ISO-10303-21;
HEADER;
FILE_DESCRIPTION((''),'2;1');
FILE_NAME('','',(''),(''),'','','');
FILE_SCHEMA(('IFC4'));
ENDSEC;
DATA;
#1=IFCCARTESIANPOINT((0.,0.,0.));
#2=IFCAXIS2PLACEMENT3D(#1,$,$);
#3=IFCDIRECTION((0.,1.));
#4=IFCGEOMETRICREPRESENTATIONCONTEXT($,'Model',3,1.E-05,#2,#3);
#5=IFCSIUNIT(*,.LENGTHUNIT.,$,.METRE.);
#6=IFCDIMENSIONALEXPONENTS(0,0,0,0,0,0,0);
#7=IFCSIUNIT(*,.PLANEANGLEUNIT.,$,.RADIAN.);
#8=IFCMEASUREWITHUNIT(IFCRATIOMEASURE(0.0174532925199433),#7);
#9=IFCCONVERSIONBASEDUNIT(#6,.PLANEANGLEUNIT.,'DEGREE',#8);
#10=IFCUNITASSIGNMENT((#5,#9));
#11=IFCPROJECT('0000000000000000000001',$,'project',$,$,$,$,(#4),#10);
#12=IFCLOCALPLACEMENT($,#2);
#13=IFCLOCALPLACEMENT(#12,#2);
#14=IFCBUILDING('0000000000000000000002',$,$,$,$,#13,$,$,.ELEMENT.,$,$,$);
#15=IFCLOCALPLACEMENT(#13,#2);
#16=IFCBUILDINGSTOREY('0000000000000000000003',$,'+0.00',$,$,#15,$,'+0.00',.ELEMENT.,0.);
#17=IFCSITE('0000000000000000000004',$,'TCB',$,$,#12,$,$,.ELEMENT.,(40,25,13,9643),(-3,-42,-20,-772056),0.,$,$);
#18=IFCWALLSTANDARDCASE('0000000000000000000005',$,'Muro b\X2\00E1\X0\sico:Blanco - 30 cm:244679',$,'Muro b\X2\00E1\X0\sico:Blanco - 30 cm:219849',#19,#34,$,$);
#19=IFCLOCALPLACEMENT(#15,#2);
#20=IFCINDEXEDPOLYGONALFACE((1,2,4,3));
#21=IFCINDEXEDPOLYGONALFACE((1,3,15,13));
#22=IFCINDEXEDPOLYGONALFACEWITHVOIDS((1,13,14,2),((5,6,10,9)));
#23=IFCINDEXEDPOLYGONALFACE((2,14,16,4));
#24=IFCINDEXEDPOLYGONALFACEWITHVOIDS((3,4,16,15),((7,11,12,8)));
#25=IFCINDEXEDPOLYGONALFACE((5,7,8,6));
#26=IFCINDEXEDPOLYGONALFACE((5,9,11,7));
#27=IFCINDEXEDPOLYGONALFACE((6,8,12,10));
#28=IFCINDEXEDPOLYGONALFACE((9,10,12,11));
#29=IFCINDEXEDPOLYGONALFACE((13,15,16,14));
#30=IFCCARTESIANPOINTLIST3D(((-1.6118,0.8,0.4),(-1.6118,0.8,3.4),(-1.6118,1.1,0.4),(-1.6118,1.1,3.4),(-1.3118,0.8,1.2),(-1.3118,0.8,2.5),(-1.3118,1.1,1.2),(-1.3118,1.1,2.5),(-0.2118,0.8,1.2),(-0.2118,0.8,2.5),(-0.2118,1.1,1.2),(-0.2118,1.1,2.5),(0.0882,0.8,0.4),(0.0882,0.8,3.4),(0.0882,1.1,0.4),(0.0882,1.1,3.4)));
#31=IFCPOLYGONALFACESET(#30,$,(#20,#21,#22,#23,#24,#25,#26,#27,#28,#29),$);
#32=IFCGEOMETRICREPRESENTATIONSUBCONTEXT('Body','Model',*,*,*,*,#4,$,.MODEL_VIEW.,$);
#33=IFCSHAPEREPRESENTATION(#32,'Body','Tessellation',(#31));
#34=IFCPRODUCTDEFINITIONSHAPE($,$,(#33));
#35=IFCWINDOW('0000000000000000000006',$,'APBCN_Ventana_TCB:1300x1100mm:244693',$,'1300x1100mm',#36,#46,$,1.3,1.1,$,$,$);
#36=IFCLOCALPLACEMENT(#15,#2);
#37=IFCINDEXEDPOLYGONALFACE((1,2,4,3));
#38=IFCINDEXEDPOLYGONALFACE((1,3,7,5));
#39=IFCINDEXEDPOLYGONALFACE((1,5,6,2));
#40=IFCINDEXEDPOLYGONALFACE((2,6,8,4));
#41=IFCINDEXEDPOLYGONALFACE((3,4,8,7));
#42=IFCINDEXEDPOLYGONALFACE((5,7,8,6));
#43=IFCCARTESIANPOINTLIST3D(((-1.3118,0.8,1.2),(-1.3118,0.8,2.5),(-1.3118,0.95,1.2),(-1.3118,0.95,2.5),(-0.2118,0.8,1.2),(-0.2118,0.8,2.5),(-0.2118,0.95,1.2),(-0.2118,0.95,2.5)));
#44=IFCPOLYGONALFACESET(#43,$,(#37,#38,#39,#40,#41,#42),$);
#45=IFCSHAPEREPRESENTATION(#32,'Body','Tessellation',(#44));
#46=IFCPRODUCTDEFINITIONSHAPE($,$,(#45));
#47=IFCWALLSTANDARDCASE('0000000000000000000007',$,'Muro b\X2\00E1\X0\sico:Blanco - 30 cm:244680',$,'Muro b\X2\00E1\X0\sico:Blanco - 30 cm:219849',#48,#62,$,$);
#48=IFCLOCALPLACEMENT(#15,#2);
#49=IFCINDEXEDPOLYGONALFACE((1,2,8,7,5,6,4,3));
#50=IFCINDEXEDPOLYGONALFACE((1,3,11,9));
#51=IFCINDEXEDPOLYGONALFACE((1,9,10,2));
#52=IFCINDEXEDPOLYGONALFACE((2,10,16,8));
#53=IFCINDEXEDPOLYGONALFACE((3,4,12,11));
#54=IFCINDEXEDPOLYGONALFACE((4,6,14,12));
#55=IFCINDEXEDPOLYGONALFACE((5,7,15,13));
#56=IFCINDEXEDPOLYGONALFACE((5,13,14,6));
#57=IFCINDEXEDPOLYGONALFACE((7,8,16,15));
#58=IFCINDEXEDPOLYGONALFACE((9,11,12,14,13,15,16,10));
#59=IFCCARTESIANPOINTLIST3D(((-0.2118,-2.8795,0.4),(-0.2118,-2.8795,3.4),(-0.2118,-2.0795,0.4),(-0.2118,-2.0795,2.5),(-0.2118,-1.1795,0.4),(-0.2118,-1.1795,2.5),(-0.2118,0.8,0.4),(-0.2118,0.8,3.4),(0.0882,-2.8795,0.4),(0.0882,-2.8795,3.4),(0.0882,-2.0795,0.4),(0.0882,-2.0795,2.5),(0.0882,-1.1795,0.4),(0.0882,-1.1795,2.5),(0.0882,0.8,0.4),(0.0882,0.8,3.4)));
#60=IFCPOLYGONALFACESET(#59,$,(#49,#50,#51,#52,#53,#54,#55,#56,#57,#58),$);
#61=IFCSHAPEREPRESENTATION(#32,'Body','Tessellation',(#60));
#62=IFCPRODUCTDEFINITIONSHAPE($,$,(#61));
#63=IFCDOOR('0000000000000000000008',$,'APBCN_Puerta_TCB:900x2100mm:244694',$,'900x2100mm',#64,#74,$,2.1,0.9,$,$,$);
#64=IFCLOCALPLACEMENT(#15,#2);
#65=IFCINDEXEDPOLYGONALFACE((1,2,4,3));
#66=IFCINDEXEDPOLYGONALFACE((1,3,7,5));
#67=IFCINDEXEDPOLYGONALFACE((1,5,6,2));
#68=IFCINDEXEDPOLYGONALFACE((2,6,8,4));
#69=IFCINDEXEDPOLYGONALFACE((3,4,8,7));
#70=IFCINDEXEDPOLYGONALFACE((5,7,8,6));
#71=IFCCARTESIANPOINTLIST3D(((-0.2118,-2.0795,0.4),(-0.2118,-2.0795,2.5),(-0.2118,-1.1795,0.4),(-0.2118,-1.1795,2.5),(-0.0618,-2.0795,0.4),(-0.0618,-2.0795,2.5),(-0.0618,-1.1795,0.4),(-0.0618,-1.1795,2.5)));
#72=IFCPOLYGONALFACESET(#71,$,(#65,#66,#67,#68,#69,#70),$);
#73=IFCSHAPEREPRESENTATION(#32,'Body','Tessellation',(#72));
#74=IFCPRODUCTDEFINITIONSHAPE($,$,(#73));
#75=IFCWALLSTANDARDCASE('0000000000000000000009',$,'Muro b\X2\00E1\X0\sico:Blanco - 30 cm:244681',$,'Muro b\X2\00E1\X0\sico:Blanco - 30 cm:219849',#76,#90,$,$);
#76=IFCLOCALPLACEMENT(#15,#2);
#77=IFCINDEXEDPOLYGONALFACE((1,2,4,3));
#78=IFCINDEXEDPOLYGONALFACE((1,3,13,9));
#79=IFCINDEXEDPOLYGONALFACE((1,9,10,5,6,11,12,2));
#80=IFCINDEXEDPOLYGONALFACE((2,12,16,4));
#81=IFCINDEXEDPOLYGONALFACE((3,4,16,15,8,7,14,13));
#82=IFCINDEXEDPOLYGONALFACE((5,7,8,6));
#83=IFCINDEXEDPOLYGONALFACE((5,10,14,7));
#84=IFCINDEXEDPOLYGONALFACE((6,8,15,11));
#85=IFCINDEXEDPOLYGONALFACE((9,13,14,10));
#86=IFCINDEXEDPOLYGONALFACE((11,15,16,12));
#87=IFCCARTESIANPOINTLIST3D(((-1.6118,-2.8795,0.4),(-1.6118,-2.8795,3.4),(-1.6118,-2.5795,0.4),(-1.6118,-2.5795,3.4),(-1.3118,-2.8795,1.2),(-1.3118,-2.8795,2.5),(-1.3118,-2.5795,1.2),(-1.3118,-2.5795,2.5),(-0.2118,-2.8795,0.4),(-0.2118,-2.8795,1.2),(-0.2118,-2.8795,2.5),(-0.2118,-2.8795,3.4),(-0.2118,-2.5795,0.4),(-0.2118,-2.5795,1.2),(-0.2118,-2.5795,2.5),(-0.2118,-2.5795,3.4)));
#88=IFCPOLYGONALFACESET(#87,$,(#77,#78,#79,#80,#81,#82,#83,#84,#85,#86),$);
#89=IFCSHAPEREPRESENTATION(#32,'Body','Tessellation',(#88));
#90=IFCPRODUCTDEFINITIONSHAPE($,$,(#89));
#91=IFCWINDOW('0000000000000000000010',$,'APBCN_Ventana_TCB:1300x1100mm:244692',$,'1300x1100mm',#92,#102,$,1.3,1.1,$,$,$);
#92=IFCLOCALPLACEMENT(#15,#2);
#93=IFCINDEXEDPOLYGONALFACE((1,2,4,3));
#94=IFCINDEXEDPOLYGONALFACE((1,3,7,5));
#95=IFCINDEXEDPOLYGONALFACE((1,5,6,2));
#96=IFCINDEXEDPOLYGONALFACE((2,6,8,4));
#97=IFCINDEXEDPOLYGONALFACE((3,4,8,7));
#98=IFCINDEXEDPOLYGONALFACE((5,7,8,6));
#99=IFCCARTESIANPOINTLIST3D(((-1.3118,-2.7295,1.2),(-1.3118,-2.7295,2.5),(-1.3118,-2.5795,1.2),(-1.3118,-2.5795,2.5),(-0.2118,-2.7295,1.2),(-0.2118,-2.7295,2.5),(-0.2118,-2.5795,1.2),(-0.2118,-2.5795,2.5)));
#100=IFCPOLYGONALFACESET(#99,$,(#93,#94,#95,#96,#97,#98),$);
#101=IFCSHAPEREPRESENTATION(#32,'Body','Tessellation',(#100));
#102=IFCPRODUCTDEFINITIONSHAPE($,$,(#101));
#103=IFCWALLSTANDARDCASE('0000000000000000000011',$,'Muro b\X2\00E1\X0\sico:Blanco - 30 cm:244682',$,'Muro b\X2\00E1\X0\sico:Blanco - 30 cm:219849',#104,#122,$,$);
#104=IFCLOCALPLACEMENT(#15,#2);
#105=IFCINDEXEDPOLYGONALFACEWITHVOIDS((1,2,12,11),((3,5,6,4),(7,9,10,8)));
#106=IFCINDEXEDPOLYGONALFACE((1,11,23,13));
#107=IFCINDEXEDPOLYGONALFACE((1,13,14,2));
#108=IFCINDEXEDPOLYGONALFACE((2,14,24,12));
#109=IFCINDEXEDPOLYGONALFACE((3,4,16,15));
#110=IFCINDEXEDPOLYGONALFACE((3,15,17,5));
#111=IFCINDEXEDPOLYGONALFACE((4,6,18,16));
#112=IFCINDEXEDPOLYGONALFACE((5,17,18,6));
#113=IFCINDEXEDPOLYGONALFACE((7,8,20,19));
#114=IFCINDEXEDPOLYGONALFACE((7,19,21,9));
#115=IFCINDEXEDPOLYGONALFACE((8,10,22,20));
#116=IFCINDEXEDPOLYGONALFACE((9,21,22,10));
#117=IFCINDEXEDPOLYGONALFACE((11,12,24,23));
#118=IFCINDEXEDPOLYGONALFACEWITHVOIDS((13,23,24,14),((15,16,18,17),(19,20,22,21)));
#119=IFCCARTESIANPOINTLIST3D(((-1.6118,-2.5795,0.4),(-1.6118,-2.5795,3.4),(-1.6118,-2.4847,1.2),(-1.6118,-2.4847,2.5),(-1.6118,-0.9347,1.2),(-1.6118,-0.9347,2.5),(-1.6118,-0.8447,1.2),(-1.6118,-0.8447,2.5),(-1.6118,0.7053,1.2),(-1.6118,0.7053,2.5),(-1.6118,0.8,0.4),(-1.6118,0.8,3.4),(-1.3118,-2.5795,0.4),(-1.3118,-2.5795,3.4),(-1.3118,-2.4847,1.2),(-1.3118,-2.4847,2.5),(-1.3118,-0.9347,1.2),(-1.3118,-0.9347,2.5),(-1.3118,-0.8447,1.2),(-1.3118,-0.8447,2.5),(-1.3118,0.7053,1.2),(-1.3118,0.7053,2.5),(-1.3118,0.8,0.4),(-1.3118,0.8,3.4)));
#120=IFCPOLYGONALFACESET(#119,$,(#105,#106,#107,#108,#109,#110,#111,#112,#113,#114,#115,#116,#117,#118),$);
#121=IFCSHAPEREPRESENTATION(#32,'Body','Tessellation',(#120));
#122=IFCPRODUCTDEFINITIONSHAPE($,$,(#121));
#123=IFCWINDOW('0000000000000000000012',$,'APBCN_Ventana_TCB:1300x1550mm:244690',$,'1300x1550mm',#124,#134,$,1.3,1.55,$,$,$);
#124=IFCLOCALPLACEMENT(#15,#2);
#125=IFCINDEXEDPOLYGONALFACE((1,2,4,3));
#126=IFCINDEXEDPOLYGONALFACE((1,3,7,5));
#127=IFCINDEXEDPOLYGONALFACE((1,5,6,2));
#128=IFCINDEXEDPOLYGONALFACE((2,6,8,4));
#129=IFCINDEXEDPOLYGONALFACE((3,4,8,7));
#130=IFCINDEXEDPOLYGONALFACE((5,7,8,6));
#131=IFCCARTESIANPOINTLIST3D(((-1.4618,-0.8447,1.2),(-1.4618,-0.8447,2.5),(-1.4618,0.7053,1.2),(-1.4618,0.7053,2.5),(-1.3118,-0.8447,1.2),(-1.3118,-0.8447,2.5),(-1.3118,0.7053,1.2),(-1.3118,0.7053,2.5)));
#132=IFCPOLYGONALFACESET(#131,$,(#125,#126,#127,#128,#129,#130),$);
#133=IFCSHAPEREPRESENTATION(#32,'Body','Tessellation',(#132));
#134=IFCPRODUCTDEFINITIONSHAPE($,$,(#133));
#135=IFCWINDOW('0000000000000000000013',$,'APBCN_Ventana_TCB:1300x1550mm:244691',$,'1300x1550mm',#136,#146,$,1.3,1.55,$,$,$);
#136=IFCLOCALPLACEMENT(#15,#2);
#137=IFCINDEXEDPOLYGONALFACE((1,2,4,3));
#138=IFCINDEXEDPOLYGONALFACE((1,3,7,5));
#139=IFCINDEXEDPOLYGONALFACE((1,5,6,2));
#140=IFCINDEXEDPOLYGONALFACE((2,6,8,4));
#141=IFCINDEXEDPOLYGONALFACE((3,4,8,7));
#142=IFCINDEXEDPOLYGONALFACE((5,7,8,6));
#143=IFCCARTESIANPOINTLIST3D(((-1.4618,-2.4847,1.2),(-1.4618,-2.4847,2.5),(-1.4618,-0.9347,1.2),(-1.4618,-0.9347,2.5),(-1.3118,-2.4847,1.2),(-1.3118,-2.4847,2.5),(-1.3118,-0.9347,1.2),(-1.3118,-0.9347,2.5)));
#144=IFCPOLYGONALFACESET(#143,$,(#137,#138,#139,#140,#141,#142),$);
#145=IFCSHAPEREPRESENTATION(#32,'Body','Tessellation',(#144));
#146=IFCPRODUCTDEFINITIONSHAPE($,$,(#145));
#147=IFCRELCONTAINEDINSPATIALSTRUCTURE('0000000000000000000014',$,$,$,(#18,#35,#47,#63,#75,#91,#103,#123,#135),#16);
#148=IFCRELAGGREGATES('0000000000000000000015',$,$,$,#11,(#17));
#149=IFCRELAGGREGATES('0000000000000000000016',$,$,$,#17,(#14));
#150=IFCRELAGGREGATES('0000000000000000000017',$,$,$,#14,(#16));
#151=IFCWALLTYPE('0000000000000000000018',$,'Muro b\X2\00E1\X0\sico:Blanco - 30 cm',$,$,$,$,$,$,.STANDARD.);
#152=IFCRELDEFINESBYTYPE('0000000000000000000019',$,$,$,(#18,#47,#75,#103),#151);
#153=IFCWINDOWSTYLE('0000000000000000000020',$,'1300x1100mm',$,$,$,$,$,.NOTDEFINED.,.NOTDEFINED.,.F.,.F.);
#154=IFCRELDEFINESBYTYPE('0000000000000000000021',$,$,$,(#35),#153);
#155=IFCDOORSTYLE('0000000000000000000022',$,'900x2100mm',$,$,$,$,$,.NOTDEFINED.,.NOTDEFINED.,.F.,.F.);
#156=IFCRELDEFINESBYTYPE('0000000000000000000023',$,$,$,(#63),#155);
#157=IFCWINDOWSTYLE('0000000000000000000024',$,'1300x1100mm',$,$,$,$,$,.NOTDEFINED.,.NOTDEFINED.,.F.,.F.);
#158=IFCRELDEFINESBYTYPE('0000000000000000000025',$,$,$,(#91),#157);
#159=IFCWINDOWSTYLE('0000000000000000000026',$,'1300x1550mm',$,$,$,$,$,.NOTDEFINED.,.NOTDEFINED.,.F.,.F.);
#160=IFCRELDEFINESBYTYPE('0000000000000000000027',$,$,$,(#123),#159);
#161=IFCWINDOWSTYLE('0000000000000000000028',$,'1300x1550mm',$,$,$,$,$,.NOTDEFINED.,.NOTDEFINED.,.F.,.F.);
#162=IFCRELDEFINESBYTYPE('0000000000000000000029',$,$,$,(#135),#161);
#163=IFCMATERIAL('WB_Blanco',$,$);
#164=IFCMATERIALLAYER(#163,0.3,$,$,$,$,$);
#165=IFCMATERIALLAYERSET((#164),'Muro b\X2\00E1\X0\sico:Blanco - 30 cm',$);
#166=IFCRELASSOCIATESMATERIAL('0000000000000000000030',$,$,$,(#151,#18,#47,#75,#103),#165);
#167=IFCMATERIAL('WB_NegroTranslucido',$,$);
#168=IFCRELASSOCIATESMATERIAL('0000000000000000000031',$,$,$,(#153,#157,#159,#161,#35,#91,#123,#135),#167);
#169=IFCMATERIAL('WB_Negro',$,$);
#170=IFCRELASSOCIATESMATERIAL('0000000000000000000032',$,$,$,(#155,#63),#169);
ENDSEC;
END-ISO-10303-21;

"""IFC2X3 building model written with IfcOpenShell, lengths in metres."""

from ifc_helpers import new_model, entity, si_unit, converted_unit, direction, frame, frame_2d, origin, origin_2d_with_axis, place, context, subcontext, project, spatial, rectangle, extrude, source, transform, mapped, material, layer, layer_set, layer_usage, type_object, type_shapes, element, fill, save


model = new_model("IFC2X3")

# Units and contexts
model_context = context("Model", 3, precision=1e-05, world=origin(), true_north=direction((0.0, 1.0)))
body_context = subcontext(model_context, "Body", "Model", "MODEL_VIEW")
ifc_project = project(units=[si_unit("LENGTHUNIT", "METRE"), converted_unit("PLANEANGLEUNIT", "DEGREE", entity("IfcRatioMeasure", 0.0174532925199433), si_unit("PLANEANGLEUNIT", "RADIAN"), dimensions=[0, 0, 0, 0, 0, 0, 0])], contexts=[model_context])

# Site, building, storey
site_placement = place(None, origin())
site = spatial("IfcSite", under=ifc_project, at=site_placement, Name="TCB", CompositionType="ELEMENT", RefLatitude=(40, 25, 13, 9643), RefLongitude=(-3, -42, -20, -772056), RefElevation=0.0)
building_placement = place(site_placement, origin())
building = spatial("IfcBuilding", under=site, at=building_placement, CompositionType="ELEMENT")
storey_placement = place(building_placement, origin())
storey = spatial("IfcBuildingStorey", under=building, at=storey_placement, Name="+0.00", LongName="+0.00", CompositionType="ELEMENT", Elevation=0.0)

# Shared definitions
ifc_material_1 = material(Name="WB_Blanco")
ifc_layer_1 = layer(ifc_material_1, 0.3)
ifc_layer_set_1 = layer_set([ifc_layer_1], Name="Muro básico:Blanco - 30 cm")
wall_type = type_object("IfcWallType", Name="Muro básico:Blanco - 30 cm", PredefinedType="STANDARD", material=ifc_layer_set_1)
ifc_material_2 = material(Name="WB_NegroTranslucido")
window_style_1 = type_object("IfcWindowStyle", Name="1300x1100mm", ConstructionType="NOTDEFINED", OperationType="NOTDEFINED", ParameterTakesPrecedence=False, Sizeable=False, material=ifc_material_2)
shared_shape_1 = source(origin(), body_context, "Body", "SweptSolid", [
    extrude(rectangle(XDim=0.15, YDim=1.1, at=frame_2d((0.0, 0.0), x_axis=(1.0, 0.0))), frame((0.55, 0.075, 0.0), z_axis=(0.0, 0.0, 1.0), x_axis=(0.0, 1.0, 0.0)), (0.0, 0.0, 1.0), 1.3),
])
type_shapes(window_style_1, [shared_shape_1])

# Shared definitions
ifc_material_3 = material(Name="WB_Negro")
door_style = type_object("IfcDoorStyle", Name="900x2100mm", ConstructionType="NOTDEFINED", OperationType="NOTDEFINED", ParameterTakesPrecedence=False, Sizeable=False, material=ifc_material_3)
shared_shape_2 = source(origin(), body_context, "Body", "SweptSolid", [
    extrude(rectangle(XDim=0.15, YDim=0.9, at=frame_2d((0.0, 0.0), x_axis=(1.0, 0.0))), frame((0.45, 0.075, 0.0), z_axis=(0.0, 0.0, 1.0), x_axis=(0.0, 1.0, 0.0)), (0.0, 0.0, 1.0), 2.1),
])
type_shapes(door_style, [shared_shape_2])

# Shared definitions
window_style_2 = type_object("IfcWindowStyle", Name="1300x1100mm", ConstructionType="NOTDEFINED", OperationType="NOTDEFINED", ParameterTakesPrecedence=False, Sizeable=False, material=ifc_material_2)
shared_shape_3 = source(origin(), body_context, "Body", "SweptSolid", [
    extrude(rectangle(XDim=1.1, YDim=0.15, at=origin_2d_with_axis()), frame((0.55, 0.075, 0.0)), (0.0, 0.0, 1.0), 1.3),
])
type_shapes(window_style_2, [shared_shape_3])

# Shared definitions
window_style_3 = type_object("IfcWindowStyle", Name="1300x1550mm", ConstructionType="NOTDEFINED", OperationType="NOTDEFINED", ParameterTakesPrecedence=False, Sizeable=False, material=ifc_material_2)
shared_shape_4 = source(origin(), body_context, "Body", "SweptSolid", [
    extrude(rectangle(XDim=1.55, YDim=0.15, at=origin_2d_with_axis()), frame((0.775, 0.075, 0.0)), (0.0, 0.0, 1.0), 1.3),
])
type_shapes(window_style_3, [shared_shape_4])
window_style_4 = type_object("IfcWindowStyle", Name="1300x1550mm", ConstructionType="NOTDEFINED", OperationType="NOTDEFINED", ParameterTakesPrecedence=False, Sizeable=False, material=ifc_material_2)
shared_shape_5 = source(origin(), body_context, "Body", "SweptSolid", [
    extrude(rectangle(XDim=0.15, YDim=1.55, at=origin_2d_with_axis()), frame((0.775, 0.075, 0.0), z_axis=(0.0, 0.0, 1.0), x_axis=(0.0, 1.0, 0.0)), (0.0, 0.0, 1.0), 1.3),
])
type_shapes(window_style_4, [shared_shape_5])

# Wall, opening, window
ifc_layer_usage_1 = layer_usage(ifc_layer_set_1, "AXIS2", "NEGATIVE", 0.15)
wall_1_placement = place(storey_placement, frame((-1.6118, 0.95, 0.4)))
wall_1 = element("IfcWallStandardCase", 1, at=wall_1_placement, inside=storey, type_object=wall_type, material=ifc_layer_usage_1, Name="Muro básico:Blanco - 30 cm:244679", ObjectType="Muro básico:Blanco - 30 cm:219849", context=body_context, shape_type="SweptSolid", body=[
    extrude(rectangle(XDim=1.7, YDim=0.3, at=frame_2d((0.85, 0.0), x_axis=(-1.0, 0.0))), origin(), (0.0, 0.0, 1.0), 3.0),
])
opening_1_placement = place(wall_1_placement, frame((0.3, -0.15, 0.8)))
opening_1 = element("IfcOpeningElement", 2, at=opening_1_placement, cuts=wall_1, ObjectType="Opening", context=body_context, shape_type="SweptSolid", body=[
    extrude(rectangle(XDim=1.3, YDim=1.1, at=frame_2d((0.65, 0.55), x_axis=(1.0, 0.0))), frame((0.0, 0.0, 0.0), z_axis=(0.0, 1.0, 0.0), x_axis=(0.0, 0.0, 1.0)), (0.0, 0.0, 1.0), 0.3),
])
window_1_placement = place(opening_1_placement, origin())
window_1 = element("IfcWindow", 3, at=window_1_placement, inside=storey, type_object=window_style_1, material=ifc_material_2, Name="APBCN_Ventana_TCB:1300x1100mm:244693", ObjectType="1300x1100mm", OverallHeight=1.3, OverallWidth=1.1, context=body_context, shape_type="MappedRepresentation", body=[
    mapped(shared_shape_1, transform((0.0, 0.0, 0.0), scale=1.0)),
])
fill(opening_1, window_1)

# Wall, opening, door
ifc_layer_usage_2 = layer_usage(ifc_layer_set_1, "AXIS2", "NEGATIVE", 0.15)
wall_2_placement = place(storey_placement, frame((-0.0618, 0.8, 0.4), z_axis=(0.0, 0.0, 1.0), x_axis=(0.0, -1.0, 0.0)))
wall_2 = element("IfcWallStandardCase", 4, at=wall_2_placement, inside=storey, type_object=wall_type, material=ifc_layer_usage_2, Name="Muro básico:Blanco - 30 cm:244680", ObjectType="Muro básico:Blanco - 30 cm:219849", context=body_context, shape_type="SweptSolid", body=[
    extrude(rectangle(XDim=3.6795, YDim=0.3, at=frame_2d((1.8397, 0.0), x_axis=(-1.0, 0.0))), origin(), (0.0, 0.0, 1.0), 3.0),
])
opening_2_placement = place(wall_2_placement, frame((1.9795, -0.15, 0.0)))
opening_2 = element("IfcOpeningElement", 5, at=opening_2_placement, cuts=wall_2, ObjectType="Opening", context=body_context, shape_type="SweptSolid", body=[
    extrude(rectangle(XDim=2.1, YDim=0.9, at=frame_2d((1.05, 0.45), x_axis=(1.0, 0.0))), frame((0.0, 0.0, 0.0), z_axis=(0.0, 1.0, 0.0), x_axis=(0.0, 0.0, 1.0)), (0.0, 0.0, 1.0), 0.3),
])
door_1_placement = place(opening_2_placement, origin())
door_1 = element("IfcDoor", 6, at=door_1_placement, inside=storey, type_object=door_style, material=ifc_material_3, Name="APBCN_Puerta_TCB:900x2100mm:244694", ObjectType="900x2100mm", OverallHeight=2.1, OverallWidth=0.9, context=body_context, shape_type="MappedRepresentation", body=[
    mapped(shared_shape_2, transform((0.0, 0.0, 0.0), scale=1.0)),
])
fill(opening_2, door_1)

# Wall, opening, window
ifc_layer_usage_3 = layer_usage(ifc_layer_set_1, "AXIS2", "NEGATIVE", 0.15)
wall_3_placement = place(storey_placement, frame((-0.2118, -2.7295, 0.4), z_axis=(0.0, 0.0, 1.0), x_axis=(-1.0, 0.0, 0.0)))
wall_3 = element("IfcWallStandardCase", 7, at=wall_3_placement, inside=storey, type_object=wall_type, material=ifc_layer_usage_3, Name="Muro básico:Blanco - 30 cm:244681", ObjectType="Muro básico:Blanco - 30 cm:219849", context=body_context, shape_type="SweptSolid", body=[
    extrude(rectangle(XDim=1.4, YDim=0.3, at=frame_2d((0.7, 0.0), x_axis=(-1.0, 0.0))), origin(), (0.0, 0.0, 1.0), 3.0),
])
opening_3_placement = place(wall_3_placement, frame((0.0, -0.15, 0.8)))
opening_3 = element("IfcOpeningElement", 8, at=opening_3_placement, cuts=wall_3, ObjectType="Opening", context=body_context, shape_type="SweptSolid", body=[
    extrude(rectangle(XDim=1.3, YDim=1.1, at=frame_2d((0.65, 0.55), x_axis=(1.0, 0.0))), frame((0.0, 0.0, 0.0), z_axis=(0.0, 1.0, 0.0), x_axis=(0.0, 0.0, 1.0)), (0.0, 0.0, 1.0), 0.3),
])
window_2_placement = place(opening_3_placement, origin())
window_2 = element("IfcWindow", 9, at=window_2_placement, inside=storey, type_object=window_style_2, material=ifc_material_2, Name="APBCN_Ventana_TCB:1300x1100mm:244692", ObjectType="1300x1100mm", OverallHeight=1.3, OverallWidth=1.1, context=body_context, shape_type="MappedRepresentation", body=[
    mapped(shared_shape_3, transform((0.0, 0.0, 0.0), scale=1.0)),
])
fill(opening_3, window_2)

# Wall, openings, windows
ifc_layer_usage_4 = layer_usage(ifc_layer_set_1, "AXIS2", "NEGATIVE", 0.15)
wall_4_placement = place(storey_placement, frame((-1.4618, -2.5795, 0.4), z_axis=(0.0, 0.0, 1.0), x_axis=(0.0, 1.0, 0.0)))
wall_4 = element("IfcWallStandardCase", 10, at=wall_4_placement, inside=storey, type_object=wall_type, material=ifc_layer_usage_4, Name="Muro básico:Blanco - 30 cm:244682", ObjectType="Muro básico:Blanco - 30 cm:219849", context=body_context, shape_type="SweptSolid", body=[
    extrude(rectangle(XDim=3.3795, YDim=0.3, at=frame_2d((1.6897, 0.0), x_axis=(-1.0, 0.0))), origin(), (0.0, 0.0, 1.0), 3.0),
])
opening_4_placement = place(wall_4_placement, frame((1.7347, -0.15, 0.8)))
opening_4 = element("IfcOpeningElement", 11, at=opening_4_placement, cuts=wall_4, ObjectType="Opening", context=body_context, shape_type="SweptSolid", body=[
    extrude(rectangle(XDim=1.3, YDim=1.55, at=frame_2d((0.65, 0.775), x_axis=(1.0, 0.0))), frame((0.0, 0.0, 0.0), z_axis=(0.0, 1.0, 0.0), x_axis=(0.0, 0.0, 1.0)), (0.0, 0.0, 1.0), 0.3),
])
opening_5_placement = place(wall_4_placement, frame((0.0947, -0.15, 0.8)))
opening_5 = element("IfcOpeningElement", 12, at=opening_5_placement, cuts=wall_4, ObjectType="Opening", context=body_context, shape_type="SweptSolid", body=[
    extrude(rectangle(XDim=1.3, YDim=1.55, at=frame_2d((0.65, 0.775), x_axis=(1.0, 0.0))), frame((0.0, 0.0, 0.0), z_axis=(0.0, 1.0, 0.0), x_axis=(0.0, 0.0, 1.0)), (0.0, 0.0, 1.0), 0.3),
])
window_3_placement = place(opening_4_placement, origin())
window_3 = element("IfcWindow", 13, at=window_3_placement, inside=storey, type_object=window_style_3, material=ifc_material_2, Name="APBCN_Ventana_TCB:1300x1550mm:244690", ObjectType="1300x1550mm", OverallHeight=1.3, OverallWidth=1.55, context=body_context, shape_type="MappedRepresentation", body=[
    mapped(shared_shape_4, transform((0.0, 0.0, 0.0), scale=1.0)),
])
fill(opening_4, window_3)
window_4_placement = place(opening_5_placement, origin())
window_4 = element("IfcWindow", 14, at=window_4_placement, inside=storey, type_object=window_style_4, material=ifc_material_2, Name="APBCN_Ventana_TCB:1300x1550mm:244691", ObjectType="1300x1550mm", OverallHeight=1.3, OverallWidth=1.55, context=body_context, shape_type="MappedRepresentation", body=[
    mapped(shared_shape_5, transform((0.0, 0.0, 0.0), scale=1.0)),
])
fill(opening_5, window_4)

save(model, "model.ifc")
